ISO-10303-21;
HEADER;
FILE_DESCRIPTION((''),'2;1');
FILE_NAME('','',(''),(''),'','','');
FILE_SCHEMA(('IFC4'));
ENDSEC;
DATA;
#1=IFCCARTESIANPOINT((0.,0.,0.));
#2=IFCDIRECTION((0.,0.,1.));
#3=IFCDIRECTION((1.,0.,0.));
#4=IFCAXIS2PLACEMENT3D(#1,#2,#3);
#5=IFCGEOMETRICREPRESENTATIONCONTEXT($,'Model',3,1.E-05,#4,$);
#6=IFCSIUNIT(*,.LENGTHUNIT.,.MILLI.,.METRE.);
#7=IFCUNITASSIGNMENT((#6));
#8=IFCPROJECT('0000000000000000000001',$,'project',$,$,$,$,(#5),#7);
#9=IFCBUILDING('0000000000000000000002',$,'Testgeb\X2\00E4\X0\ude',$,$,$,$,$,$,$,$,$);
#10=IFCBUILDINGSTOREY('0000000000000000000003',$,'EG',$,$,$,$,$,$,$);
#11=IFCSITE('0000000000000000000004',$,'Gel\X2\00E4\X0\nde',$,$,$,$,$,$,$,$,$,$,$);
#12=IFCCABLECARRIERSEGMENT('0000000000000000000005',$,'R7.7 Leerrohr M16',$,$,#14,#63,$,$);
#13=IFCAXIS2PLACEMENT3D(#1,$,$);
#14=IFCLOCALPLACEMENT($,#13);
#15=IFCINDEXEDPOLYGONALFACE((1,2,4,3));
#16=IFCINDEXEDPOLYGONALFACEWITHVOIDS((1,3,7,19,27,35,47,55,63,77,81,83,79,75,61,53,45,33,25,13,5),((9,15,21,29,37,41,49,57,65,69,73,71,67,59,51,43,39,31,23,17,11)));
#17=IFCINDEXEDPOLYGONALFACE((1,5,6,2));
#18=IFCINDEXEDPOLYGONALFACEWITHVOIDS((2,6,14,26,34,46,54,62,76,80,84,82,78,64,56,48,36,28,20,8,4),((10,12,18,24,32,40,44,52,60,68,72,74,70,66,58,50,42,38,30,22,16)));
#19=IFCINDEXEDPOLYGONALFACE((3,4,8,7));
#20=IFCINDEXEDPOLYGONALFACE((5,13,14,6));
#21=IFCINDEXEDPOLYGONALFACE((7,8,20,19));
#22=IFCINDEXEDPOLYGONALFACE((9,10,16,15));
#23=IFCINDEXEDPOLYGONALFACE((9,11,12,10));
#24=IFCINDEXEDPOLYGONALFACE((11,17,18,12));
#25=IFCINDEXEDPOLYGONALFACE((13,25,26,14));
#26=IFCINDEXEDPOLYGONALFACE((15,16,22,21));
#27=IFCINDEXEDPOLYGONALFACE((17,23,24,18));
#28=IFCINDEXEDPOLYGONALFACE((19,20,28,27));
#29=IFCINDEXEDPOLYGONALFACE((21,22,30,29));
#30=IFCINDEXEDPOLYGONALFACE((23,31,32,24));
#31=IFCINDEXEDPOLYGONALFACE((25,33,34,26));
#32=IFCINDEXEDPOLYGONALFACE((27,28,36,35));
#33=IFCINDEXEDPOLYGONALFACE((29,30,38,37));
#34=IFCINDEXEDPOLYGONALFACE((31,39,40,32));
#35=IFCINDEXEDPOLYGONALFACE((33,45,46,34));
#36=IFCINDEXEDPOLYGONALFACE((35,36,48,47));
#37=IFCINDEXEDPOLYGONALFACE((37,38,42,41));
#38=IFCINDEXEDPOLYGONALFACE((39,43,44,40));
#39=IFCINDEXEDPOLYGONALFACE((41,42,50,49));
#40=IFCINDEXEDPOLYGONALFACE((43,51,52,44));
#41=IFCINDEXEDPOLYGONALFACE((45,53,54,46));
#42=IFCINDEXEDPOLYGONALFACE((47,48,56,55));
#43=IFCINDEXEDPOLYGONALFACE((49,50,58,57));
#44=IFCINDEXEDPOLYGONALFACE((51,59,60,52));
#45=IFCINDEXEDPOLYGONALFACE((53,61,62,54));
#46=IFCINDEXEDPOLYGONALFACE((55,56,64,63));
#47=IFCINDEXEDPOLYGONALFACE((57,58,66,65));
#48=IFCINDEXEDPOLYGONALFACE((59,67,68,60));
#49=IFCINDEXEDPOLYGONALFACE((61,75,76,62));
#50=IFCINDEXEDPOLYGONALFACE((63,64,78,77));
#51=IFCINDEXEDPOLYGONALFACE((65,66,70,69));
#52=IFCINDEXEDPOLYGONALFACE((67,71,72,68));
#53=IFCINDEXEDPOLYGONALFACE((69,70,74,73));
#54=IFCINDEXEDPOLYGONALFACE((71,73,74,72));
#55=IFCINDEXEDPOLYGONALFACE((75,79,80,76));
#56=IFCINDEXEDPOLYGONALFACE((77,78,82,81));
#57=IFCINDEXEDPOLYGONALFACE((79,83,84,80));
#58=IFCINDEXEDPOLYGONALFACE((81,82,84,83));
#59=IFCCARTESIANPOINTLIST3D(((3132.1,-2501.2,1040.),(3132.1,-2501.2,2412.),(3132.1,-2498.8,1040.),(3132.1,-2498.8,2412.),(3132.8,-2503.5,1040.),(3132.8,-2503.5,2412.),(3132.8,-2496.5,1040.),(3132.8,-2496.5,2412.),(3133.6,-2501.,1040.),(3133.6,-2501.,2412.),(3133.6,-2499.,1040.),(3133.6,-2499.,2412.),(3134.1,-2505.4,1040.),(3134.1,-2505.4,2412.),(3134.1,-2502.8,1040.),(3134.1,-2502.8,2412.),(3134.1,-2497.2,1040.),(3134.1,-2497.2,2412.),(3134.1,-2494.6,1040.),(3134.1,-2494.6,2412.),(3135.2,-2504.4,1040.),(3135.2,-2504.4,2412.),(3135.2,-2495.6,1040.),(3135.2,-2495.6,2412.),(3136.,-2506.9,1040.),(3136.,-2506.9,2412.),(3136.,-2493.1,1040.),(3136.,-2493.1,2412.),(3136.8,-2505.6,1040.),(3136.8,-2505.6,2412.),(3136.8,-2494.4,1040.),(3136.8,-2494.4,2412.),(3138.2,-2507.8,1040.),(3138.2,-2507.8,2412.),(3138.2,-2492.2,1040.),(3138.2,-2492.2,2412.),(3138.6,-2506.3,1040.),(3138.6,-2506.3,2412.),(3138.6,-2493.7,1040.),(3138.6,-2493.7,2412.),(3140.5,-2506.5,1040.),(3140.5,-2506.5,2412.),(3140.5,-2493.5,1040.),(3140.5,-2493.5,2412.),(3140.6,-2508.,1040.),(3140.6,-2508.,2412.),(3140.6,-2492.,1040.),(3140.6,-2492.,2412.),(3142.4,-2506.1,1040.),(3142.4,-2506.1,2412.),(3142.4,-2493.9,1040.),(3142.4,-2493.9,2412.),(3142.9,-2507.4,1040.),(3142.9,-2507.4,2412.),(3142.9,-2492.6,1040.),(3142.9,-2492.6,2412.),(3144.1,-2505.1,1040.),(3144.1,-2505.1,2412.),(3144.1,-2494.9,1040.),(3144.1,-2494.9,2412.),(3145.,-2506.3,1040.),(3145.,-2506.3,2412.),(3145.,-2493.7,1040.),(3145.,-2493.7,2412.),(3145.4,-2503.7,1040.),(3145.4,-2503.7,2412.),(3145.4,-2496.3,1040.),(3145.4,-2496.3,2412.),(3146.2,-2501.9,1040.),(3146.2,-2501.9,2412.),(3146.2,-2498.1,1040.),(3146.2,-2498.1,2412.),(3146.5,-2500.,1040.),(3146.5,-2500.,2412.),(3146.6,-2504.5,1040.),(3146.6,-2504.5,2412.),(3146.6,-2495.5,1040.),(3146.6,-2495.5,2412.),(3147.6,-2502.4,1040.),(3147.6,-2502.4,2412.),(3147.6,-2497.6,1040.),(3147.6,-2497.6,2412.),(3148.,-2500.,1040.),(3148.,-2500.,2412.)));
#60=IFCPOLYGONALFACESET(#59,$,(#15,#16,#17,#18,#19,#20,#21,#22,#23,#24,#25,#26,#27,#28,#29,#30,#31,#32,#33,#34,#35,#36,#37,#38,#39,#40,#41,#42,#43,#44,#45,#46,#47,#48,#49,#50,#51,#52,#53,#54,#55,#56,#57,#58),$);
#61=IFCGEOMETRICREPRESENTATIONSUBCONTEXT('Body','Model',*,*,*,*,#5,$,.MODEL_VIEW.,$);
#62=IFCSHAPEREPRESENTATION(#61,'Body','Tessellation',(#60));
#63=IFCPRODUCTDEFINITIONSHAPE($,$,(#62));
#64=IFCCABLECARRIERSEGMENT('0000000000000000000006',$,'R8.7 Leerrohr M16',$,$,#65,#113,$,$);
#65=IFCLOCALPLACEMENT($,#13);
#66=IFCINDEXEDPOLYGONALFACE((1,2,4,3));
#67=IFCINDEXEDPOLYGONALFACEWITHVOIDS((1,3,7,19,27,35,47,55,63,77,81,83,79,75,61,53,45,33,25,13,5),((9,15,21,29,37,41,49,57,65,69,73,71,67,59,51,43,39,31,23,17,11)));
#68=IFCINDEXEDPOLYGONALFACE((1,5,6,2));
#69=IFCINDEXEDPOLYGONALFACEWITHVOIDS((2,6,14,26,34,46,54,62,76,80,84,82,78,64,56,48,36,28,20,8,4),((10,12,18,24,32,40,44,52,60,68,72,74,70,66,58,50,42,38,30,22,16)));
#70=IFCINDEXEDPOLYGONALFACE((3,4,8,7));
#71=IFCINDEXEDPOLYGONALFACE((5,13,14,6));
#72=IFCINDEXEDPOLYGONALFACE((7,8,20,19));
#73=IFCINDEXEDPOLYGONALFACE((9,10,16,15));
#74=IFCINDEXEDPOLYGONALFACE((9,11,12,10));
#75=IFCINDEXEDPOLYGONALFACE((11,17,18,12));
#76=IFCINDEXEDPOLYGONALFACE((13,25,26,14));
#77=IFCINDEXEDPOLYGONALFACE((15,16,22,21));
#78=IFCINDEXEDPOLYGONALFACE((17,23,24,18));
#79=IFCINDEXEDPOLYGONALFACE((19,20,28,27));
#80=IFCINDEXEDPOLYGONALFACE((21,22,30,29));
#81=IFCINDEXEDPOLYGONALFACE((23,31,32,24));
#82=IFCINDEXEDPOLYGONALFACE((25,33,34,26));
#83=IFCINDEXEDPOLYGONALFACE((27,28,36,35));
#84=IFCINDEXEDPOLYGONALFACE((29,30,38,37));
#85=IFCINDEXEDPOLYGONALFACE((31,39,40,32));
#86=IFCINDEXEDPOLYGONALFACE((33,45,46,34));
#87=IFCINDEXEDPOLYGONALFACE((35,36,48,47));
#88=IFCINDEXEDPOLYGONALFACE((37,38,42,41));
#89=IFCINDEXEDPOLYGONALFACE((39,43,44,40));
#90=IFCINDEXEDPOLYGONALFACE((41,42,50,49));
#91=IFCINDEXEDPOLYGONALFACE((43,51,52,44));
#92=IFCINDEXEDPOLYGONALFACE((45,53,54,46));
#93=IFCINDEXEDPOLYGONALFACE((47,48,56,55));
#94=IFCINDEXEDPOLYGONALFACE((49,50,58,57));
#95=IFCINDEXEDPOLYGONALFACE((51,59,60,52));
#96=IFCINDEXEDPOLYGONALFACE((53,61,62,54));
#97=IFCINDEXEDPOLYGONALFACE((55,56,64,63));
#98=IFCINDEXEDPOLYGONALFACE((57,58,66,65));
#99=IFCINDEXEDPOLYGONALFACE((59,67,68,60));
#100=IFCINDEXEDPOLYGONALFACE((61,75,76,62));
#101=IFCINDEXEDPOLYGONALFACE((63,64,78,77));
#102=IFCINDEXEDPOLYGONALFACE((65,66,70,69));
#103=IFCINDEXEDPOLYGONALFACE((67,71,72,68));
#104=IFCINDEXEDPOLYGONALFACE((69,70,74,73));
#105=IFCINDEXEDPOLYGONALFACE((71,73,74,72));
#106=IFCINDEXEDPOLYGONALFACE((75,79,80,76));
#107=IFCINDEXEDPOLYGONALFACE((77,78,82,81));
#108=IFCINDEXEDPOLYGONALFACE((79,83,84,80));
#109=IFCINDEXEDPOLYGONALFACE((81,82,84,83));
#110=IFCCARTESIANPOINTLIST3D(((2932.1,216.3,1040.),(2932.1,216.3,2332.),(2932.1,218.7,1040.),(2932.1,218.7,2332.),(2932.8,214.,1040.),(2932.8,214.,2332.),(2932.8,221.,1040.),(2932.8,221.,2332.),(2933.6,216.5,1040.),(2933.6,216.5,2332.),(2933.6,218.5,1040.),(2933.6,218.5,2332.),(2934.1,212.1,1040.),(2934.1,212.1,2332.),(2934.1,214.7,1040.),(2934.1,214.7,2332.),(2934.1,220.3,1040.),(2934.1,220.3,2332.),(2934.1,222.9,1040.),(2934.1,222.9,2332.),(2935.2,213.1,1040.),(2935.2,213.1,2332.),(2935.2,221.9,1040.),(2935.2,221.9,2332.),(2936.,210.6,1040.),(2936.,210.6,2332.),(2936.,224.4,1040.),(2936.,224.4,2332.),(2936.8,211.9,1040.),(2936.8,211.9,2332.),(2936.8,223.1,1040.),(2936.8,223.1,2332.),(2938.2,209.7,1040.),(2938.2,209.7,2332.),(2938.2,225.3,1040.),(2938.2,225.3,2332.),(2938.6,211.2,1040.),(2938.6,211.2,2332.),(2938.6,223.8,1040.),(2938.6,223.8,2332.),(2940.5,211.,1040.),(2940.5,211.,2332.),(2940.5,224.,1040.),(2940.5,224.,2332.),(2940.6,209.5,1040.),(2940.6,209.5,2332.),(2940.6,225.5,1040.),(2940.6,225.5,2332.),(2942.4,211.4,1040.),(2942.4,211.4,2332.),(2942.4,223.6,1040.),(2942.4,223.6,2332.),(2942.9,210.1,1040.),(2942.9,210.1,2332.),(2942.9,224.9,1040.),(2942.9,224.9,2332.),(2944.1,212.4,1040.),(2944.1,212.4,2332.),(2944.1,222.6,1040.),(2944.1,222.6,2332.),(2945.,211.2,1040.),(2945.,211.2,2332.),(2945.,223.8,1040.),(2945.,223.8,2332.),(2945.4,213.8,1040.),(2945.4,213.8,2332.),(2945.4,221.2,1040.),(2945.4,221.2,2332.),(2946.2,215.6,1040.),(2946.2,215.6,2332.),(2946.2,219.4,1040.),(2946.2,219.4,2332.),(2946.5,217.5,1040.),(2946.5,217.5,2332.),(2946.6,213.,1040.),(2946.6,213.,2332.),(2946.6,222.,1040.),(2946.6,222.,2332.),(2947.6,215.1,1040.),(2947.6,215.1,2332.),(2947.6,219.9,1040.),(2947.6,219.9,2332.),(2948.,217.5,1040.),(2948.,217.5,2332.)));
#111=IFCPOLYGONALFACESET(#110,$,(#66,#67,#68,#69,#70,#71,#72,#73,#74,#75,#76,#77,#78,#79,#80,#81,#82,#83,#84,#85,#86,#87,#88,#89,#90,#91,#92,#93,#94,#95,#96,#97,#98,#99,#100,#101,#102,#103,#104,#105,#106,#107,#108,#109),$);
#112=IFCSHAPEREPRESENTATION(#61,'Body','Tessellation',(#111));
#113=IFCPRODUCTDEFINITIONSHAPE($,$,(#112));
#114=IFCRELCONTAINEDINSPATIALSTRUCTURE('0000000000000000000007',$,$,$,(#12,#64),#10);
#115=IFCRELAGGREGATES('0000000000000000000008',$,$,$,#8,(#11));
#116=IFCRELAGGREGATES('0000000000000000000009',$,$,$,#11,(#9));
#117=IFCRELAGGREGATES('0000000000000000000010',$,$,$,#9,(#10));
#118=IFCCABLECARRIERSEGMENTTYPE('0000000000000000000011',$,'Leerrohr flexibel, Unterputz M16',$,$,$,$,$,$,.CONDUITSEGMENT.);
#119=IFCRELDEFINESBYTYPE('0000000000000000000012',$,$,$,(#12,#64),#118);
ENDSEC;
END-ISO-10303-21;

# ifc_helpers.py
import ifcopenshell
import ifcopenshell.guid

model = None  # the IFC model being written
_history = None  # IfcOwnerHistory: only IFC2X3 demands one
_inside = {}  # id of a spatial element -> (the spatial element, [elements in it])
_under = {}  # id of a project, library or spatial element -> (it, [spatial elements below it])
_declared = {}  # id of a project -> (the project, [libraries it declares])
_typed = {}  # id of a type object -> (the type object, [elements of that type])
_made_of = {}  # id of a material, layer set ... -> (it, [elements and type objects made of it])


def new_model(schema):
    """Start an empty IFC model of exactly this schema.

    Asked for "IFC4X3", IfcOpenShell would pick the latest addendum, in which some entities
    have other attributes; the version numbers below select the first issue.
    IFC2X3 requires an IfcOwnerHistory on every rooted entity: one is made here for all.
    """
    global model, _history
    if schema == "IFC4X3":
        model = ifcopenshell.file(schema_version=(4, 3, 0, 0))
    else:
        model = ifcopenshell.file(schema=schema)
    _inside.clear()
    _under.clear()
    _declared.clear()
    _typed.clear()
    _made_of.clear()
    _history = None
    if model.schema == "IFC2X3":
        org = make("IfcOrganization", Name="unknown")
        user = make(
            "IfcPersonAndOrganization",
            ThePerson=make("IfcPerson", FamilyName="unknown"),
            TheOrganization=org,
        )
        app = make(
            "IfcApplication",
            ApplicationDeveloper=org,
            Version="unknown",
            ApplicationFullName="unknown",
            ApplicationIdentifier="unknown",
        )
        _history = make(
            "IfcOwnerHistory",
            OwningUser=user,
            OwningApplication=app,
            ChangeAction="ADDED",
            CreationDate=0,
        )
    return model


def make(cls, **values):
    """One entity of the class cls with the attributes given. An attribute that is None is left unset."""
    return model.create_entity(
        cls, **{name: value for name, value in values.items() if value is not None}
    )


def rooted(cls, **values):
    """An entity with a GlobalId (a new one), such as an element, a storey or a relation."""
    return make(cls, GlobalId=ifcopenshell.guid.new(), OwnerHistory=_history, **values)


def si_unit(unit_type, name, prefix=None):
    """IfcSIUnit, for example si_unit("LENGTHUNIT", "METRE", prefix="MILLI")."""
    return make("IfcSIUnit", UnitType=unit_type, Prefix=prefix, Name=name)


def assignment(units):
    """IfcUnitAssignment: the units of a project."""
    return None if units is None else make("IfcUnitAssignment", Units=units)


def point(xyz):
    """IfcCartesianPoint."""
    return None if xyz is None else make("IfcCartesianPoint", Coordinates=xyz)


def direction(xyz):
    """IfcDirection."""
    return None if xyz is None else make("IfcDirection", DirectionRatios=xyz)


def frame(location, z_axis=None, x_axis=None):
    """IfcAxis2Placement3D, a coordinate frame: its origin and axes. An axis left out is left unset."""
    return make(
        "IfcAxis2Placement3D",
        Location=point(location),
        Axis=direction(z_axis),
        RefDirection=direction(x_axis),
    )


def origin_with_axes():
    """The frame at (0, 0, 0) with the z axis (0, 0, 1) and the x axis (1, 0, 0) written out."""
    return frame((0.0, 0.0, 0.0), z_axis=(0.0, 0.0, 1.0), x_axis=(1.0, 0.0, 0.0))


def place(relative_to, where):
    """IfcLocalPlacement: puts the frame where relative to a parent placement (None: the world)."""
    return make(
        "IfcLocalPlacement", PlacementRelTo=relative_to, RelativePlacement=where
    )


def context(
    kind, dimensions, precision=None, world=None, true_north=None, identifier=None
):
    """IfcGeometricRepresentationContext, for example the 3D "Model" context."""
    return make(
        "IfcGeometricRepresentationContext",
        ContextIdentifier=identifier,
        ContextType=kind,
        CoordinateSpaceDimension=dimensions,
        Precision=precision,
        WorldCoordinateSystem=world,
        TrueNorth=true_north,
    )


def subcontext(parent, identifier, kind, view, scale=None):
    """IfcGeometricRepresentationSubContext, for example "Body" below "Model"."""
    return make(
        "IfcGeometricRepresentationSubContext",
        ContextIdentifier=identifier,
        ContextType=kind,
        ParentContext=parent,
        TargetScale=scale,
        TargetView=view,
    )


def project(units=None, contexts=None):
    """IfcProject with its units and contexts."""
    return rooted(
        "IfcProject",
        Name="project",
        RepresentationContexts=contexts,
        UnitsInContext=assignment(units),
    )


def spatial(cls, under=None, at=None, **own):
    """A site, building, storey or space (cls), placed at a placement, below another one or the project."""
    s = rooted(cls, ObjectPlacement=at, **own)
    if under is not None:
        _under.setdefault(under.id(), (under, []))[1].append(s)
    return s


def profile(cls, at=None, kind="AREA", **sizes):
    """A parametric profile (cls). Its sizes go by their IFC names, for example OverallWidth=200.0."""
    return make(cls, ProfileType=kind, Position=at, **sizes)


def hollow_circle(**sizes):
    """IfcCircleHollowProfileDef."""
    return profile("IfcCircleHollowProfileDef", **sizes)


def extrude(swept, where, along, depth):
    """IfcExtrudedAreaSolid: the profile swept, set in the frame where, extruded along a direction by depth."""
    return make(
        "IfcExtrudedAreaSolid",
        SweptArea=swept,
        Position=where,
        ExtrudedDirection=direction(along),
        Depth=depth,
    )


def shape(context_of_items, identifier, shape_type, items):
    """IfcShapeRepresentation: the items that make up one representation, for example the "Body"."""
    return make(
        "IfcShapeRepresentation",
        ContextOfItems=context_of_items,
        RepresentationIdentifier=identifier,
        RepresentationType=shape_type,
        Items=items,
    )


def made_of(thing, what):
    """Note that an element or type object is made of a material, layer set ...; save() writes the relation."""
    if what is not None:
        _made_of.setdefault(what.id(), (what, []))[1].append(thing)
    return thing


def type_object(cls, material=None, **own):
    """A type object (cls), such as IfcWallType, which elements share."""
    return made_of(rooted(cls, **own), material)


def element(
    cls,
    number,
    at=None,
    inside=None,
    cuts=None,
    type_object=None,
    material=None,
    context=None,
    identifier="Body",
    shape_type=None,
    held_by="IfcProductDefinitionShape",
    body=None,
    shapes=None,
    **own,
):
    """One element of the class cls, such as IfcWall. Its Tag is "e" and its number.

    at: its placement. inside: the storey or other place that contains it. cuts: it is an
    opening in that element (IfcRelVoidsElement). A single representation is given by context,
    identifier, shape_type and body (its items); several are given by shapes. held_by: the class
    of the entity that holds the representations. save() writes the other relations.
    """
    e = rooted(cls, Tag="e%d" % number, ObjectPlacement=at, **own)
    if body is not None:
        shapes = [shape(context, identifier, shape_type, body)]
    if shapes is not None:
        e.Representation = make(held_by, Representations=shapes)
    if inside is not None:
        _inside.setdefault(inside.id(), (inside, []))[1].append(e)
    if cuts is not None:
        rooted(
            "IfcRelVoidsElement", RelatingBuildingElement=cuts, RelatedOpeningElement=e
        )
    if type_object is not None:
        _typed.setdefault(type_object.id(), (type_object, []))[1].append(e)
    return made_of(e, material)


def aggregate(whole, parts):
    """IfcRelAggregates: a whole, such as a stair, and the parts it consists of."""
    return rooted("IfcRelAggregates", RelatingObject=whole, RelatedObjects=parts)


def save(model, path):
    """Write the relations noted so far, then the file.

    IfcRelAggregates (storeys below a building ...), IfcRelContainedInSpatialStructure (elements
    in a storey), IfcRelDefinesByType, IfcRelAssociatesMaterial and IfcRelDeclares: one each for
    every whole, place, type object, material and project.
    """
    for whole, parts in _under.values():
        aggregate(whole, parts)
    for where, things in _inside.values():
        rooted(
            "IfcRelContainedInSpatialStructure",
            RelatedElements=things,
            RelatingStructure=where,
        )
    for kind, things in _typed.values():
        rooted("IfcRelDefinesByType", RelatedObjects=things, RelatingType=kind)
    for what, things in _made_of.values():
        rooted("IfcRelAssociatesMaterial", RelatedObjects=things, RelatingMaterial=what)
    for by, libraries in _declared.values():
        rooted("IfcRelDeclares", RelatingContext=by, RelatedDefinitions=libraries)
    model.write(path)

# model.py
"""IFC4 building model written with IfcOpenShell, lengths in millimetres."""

from ifc_helpers import new_model, si_unit, frame, origin_with_axes, place, context, subcontext, project, spatial, hollow_circle, extrude, type_object, element, save


model = new_model("IFC4")

# Units and contexts
model_context = context("Model", 3, precision=1e-05, world=origin_with_axes())
body_context = subcontext(model_context, "Body", "Model", "MODEL_VIEW")
ifc_project = project(units=[si_unit("LENGTHUNIT", "METRE", prefix="MILLI")], contexts=[model_context])

# Site, building, storey
site = spatial("IfcSite", under=ifc_project, Name="Gelände")
building = spatial("IfcBuilding", under=site, Name="Testgebäude")
storey = spatial("IfcBuildingStorey", under=building, Name="EG")

# Cable carrier segments
cable_carrier_segment_type_1 = type_object("IfcCableCarrierSegmentType", Name="Leerrohr flexibel, Unterputz M16", PredefinedType="CONDUITSEGMENT")
cable_carrier_segment_1_placement = place(None, frame((3140.0, -2500.0, 2412.0), z_axis=(0.0, 0.0, -1.0), x_axis=(1.0, 0.0, 0.0)))
element("IfcCableCarrierSegment", 1, at=cable_carrier_segment_1_placement, inside=storey, type_object=cable_carrier_segment_type_1, Name="R7.7 Leerrohr M16", context=body_context, shape_type="SweptSolid", body=[
    extrude(hollow_circle(Radius=8.0, WallThickness=1.5), None, (0.0, 0.0, 1.0), 1372.0),
])
cable_carrier_segment_2_placement = place(None, frame((2940.0, 217.5, 2332.0), z_axis=(0.0, 0.0, -1.0), x_axis=(1.0, 0.0, 0.0)))
element("IfcCableCarrierSegment", 2, at=cable_carrier_segment_2_placement, inside=storey, type_object=cable_carrier_segment_type_1, Name="R8.7 Leerrohr M16", context=body_context, shape_type="SweptSolid", body=[
    extrude(hollow_circle(Radius=8.0, WallThickness=1.5), None, (0.0, 0.0, 1.0), 1292.0),
])

save(model, "model.ifc")
